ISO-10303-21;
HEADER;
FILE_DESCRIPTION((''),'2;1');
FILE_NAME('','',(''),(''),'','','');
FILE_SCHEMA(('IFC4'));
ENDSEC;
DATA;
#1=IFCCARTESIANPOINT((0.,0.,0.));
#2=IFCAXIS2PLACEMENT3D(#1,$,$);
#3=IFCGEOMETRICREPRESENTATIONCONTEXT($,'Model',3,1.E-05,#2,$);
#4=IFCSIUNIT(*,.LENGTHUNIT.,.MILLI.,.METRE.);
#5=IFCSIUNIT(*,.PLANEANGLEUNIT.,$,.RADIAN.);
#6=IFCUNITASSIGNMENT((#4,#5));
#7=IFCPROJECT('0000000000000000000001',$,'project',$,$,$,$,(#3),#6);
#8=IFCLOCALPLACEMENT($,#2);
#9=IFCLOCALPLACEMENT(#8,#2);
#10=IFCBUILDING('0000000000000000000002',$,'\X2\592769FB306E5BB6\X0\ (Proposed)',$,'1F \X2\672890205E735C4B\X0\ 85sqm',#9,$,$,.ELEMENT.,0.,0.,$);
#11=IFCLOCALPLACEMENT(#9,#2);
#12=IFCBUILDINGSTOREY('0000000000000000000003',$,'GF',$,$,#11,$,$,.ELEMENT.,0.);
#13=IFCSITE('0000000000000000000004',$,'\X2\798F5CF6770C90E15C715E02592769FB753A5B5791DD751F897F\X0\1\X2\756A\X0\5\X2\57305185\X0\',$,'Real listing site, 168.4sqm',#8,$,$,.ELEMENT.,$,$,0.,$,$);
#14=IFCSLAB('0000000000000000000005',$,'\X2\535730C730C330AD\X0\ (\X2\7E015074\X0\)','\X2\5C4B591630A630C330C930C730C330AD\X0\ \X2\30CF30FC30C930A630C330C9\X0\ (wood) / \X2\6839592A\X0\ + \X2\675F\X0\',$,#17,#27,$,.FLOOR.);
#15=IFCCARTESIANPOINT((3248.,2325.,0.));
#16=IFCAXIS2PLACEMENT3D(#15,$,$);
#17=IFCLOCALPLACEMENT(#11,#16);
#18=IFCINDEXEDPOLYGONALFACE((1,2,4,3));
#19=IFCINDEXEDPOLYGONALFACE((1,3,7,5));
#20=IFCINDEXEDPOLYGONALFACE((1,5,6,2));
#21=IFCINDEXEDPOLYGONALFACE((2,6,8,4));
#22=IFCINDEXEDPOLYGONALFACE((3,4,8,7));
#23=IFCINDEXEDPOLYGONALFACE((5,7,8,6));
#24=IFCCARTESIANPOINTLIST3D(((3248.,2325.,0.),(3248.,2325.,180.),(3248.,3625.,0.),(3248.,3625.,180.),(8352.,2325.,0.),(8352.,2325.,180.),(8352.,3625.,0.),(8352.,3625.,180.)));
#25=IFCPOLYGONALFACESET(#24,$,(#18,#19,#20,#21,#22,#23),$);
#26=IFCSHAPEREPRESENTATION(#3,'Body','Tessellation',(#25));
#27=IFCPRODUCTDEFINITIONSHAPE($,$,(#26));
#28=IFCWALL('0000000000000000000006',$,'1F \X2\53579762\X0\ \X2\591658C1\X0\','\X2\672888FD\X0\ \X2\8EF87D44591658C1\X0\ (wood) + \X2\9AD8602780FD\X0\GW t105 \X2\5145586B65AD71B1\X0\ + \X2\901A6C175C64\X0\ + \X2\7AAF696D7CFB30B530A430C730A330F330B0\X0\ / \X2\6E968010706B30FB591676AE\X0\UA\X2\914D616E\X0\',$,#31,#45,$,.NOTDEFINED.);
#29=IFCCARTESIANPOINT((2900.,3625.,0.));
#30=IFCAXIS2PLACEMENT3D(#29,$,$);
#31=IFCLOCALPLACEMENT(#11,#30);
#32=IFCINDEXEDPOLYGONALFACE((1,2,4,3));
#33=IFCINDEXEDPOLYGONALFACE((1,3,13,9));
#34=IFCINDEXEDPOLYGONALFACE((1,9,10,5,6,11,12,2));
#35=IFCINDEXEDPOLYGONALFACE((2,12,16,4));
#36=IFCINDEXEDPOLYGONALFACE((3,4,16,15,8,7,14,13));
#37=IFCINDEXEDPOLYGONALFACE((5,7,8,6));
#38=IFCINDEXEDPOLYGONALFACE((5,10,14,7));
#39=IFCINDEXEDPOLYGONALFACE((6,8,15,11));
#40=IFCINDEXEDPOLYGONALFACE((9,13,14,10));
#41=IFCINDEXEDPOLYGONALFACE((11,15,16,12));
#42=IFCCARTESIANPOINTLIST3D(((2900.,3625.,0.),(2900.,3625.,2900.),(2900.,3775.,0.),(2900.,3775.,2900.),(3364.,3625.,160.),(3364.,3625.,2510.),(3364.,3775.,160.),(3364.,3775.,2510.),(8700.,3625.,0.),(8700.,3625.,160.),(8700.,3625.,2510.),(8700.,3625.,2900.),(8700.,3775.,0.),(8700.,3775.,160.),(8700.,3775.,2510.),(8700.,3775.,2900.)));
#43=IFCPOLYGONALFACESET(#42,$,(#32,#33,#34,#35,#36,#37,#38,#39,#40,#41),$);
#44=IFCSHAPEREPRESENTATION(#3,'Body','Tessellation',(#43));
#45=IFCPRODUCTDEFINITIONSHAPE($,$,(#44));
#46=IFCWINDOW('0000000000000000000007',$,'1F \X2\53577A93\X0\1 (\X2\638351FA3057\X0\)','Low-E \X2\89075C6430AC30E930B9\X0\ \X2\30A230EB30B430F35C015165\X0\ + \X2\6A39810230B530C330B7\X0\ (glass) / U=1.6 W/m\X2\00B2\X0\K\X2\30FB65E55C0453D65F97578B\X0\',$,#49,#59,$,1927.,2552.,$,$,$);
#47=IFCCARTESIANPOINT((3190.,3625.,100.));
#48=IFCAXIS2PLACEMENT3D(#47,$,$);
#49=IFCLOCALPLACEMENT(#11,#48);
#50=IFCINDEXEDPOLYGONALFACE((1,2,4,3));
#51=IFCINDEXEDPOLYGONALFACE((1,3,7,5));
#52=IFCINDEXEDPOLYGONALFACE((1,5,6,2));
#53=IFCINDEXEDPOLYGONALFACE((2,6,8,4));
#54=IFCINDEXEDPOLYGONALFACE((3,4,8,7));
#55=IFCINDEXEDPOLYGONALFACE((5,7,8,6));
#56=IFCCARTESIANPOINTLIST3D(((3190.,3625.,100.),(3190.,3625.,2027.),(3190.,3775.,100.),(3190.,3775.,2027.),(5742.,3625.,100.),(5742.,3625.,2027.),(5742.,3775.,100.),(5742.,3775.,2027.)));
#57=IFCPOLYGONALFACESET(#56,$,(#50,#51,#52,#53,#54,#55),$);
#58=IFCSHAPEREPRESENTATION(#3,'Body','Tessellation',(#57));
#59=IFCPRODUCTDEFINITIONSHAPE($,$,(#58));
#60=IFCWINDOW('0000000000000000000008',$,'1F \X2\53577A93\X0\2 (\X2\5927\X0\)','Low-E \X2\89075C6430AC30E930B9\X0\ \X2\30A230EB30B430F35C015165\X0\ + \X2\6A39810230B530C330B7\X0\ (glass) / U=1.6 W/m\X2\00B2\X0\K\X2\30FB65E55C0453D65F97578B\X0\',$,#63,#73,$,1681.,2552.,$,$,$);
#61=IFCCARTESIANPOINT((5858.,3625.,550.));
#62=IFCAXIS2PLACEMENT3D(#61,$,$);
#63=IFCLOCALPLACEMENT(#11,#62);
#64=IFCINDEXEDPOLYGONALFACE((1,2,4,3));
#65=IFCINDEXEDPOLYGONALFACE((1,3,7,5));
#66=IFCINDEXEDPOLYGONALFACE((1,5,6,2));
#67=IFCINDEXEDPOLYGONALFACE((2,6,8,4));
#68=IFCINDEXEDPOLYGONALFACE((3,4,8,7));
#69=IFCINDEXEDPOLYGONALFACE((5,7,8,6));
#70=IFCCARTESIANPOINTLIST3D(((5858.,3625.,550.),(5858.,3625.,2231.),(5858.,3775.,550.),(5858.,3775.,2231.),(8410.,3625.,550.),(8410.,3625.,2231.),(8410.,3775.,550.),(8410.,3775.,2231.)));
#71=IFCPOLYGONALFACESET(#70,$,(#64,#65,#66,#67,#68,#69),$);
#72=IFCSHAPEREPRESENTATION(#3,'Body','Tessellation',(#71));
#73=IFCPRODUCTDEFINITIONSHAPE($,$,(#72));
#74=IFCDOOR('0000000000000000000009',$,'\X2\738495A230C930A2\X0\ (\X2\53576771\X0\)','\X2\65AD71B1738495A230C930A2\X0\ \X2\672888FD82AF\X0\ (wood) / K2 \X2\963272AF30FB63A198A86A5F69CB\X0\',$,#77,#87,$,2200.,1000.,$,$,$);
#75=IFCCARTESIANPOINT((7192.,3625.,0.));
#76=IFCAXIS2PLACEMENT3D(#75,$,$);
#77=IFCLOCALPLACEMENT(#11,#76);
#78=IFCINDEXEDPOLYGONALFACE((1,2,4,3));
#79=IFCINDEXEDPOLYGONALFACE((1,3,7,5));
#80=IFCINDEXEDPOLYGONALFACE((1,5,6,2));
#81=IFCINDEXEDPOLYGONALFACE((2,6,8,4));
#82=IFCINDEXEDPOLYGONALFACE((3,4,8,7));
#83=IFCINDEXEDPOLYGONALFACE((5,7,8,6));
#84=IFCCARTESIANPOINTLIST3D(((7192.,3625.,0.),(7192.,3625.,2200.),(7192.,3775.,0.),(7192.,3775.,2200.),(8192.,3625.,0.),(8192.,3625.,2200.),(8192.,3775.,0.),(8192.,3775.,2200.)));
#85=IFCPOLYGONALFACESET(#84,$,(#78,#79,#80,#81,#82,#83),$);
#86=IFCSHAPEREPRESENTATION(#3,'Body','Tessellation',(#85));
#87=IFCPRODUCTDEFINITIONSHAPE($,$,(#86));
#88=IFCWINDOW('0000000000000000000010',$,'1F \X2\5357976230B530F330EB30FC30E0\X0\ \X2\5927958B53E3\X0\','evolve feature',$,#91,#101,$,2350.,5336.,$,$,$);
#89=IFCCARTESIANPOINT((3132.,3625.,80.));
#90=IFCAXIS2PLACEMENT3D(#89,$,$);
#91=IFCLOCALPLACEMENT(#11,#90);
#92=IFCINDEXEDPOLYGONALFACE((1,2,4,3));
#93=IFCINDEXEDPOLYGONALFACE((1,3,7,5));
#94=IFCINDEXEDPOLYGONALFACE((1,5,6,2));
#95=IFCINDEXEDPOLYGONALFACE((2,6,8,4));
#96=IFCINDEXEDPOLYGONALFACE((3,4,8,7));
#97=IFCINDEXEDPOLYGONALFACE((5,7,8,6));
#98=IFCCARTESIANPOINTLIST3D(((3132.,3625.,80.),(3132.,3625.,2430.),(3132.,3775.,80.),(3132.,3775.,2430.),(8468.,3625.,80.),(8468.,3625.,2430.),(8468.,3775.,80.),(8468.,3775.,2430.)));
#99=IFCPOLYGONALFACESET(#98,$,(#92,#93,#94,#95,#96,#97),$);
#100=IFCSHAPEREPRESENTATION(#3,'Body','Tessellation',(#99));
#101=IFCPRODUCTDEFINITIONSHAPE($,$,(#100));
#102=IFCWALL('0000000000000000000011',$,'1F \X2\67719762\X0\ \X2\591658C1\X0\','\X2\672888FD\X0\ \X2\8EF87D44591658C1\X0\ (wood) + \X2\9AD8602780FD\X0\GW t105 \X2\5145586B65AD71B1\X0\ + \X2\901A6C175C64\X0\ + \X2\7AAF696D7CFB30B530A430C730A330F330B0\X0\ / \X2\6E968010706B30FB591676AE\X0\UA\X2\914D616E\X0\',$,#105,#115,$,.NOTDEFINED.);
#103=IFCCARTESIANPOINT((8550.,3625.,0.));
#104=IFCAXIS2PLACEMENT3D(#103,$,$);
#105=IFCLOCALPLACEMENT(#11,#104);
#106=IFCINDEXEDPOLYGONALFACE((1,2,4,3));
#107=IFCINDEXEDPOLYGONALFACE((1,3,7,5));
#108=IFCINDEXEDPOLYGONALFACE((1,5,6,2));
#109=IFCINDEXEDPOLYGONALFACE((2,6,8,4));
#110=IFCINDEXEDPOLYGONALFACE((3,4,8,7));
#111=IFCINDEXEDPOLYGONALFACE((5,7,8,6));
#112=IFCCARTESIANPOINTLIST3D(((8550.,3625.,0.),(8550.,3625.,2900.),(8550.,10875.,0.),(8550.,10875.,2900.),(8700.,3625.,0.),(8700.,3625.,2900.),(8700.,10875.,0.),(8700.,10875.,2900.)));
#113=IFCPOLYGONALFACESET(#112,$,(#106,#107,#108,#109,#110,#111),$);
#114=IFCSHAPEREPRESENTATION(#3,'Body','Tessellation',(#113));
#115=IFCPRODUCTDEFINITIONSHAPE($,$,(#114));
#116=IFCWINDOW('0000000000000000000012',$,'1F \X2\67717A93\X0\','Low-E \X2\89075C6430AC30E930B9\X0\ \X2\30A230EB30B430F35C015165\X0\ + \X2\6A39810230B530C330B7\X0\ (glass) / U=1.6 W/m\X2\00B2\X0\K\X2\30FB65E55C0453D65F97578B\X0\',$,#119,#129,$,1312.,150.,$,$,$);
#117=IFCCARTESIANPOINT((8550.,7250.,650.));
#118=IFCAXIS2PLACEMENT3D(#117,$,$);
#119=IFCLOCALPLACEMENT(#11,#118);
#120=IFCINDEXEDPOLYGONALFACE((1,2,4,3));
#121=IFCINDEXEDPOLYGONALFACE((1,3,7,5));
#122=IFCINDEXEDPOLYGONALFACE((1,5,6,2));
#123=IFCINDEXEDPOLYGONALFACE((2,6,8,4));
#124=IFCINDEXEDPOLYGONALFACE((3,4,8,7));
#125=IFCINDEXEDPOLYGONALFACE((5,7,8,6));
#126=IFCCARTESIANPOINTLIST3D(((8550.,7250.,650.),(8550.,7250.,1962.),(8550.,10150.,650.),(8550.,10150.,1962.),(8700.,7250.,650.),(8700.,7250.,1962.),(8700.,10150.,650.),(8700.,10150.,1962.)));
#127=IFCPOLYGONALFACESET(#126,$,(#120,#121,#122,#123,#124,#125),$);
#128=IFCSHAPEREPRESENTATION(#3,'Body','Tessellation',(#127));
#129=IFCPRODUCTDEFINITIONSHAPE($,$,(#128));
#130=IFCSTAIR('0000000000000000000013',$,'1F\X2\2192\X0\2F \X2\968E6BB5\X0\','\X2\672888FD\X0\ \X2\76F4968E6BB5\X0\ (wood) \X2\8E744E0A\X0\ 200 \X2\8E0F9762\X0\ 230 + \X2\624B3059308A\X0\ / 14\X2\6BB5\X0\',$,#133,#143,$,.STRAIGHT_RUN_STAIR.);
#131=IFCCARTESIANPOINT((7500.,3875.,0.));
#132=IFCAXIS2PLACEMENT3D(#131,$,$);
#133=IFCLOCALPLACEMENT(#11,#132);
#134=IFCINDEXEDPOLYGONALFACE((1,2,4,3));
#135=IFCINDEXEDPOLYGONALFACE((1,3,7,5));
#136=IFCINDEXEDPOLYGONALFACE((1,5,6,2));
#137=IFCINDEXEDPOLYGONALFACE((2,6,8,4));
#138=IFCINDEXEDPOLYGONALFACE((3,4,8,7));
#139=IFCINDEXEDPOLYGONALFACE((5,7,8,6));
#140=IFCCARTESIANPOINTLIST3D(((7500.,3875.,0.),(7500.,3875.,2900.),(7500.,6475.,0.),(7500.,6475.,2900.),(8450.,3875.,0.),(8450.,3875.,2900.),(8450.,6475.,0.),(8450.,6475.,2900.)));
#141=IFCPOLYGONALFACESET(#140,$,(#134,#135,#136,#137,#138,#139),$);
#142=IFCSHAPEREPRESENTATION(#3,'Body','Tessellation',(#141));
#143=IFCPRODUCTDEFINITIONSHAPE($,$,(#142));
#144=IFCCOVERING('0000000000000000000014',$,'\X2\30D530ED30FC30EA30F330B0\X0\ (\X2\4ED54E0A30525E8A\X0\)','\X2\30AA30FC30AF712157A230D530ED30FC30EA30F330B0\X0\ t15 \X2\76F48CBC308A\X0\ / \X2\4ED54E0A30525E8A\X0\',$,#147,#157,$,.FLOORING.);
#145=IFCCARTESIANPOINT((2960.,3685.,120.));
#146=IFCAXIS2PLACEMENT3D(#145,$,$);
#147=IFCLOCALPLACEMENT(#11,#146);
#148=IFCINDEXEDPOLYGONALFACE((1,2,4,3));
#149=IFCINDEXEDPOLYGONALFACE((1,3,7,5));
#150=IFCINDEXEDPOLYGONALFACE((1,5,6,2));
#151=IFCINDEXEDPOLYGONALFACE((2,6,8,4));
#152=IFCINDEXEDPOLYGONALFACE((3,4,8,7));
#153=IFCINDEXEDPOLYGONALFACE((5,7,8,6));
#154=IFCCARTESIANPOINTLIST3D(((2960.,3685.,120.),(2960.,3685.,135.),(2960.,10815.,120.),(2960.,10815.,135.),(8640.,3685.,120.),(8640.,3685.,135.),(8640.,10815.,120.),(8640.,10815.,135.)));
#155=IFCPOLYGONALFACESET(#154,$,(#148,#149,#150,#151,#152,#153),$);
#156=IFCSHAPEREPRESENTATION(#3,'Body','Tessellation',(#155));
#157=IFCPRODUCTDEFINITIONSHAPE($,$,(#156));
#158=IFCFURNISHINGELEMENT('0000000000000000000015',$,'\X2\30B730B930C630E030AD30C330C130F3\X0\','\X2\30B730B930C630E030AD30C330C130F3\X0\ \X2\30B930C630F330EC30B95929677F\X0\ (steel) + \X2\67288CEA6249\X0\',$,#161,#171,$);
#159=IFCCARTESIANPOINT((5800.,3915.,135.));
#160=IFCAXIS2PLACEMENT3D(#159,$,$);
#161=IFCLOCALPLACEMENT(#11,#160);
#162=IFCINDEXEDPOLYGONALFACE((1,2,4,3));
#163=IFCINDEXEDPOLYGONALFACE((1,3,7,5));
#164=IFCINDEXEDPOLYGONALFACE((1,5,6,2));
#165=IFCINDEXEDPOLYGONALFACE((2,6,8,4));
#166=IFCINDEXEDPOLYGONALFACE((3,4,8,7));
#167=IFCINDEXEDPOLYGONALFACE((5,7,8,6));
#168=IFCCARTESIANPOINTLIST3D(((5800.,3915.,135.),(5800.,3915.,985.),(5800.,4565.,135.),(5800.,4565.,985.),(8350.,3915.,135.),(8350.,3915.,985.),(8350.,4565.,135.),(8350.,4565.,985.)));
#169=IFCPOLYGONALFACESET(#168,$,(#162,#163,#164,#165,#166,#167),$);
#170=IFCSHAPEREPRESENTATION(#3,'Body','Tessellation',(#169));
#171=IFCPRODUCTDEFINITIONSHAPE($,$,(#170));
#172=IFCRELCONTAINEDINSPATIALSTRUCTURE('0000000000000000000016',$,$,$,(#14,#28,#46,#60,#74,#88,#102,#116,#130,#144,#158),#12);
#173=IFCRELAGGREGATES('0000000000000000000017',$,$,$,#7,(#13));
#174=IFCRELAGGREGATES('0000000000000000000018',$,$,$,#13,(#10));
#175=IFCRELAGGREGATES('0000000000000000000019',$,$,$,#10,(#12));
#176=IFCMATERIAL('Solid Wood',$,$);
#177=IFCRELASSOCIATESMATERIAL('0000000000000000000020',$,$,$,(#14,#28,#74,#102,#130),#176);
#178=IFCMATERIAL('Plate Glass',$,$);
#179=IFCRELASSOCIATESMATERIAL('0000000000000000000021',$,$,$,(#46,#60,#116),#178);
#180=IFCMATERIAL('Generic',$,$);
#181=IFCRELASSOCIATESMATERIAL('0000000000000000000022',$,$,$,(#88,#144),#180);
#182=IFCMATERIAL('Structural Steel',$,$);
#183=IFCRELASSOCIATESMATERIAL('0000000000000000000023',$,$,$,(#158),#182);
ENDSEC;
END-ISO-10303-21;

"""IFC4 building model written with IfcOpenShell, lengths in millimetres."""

from ifc_helpers import new_model, si_unit, frame, frame_2d, origin, place, context, project, spatial, rectangle, extrude, material, element, fill, save


model = new_model("IFC4")

# Units and contexts
model_context = context("Model", 3, precision=1e-05, world=origin())
ifc_project = project(units=[si_unit("LENGTHUNIT", "METRE", prefix="MILLI"), si_unit("PLANEANGLEUNIT", "RADIAN")], contexts=[model_context])

# Site, building, storey
site_placement = place(None, origin())
site = spatial("IfcSite", under=ifc_project, at=site_placement, Name="福島県郡山市大槻町字針生西1番5地内", ObjectType="Real listing site, 168.4sqm", CompositionType="ELEMENT", RefElevation=0.0)
building_placement = place(site_placement, origin())
building = spatial("IfcBuilding", under=site, at=building_placement, Name="大槻の家 (Proposed)", ObjectType="1F 木造平屋 85sqm", CompositionType="ELEMENT", ElevationOfRefHeight=0.0, ElevationOfTerrain=0.0)
storey_placement = place(building_placement, origin())
storey = spatial("IfcBuildingStorey", under=building, at=storey_placement, Name="GF", CompositionType="ELEMENT", Elevation=0.0)

# Slab
ifc_material_1 = material(Name="Solid Wood")
slab_1_placement = place(storey_placement, frame((3248.0, 2325.0, 0.0)))
element("IfcSlab", 1, at=slab_1_placement, inside=storey, material=ifc_material_1, Name="南デッキ (縁側)", Description="屋外ウッドデッキ ハードウッド (wood) / 根太 + 束", PredefinedType="FLOOR", context=model_context, shape_type="SweptSolid", body=[
    extrude(rectangle(XDim=5104.0, YDim=1300.0, at=frame_2d((2552.0, 650.0))), frame((3248.0, 2325.0, 0.0)), (0.0, 0.0, 1.0), 180.0),
])
ifc_material_2 = material(Name="Generic")

# Wall, openings, windows, door
wall_1_placement = place(storey_placement, frame((2900.0, 3625.0, 0.0)))
wall_1 = element("IfcWall", 2, at=wall_1_placement, inside=storey, material=ifc_material_1, Name="1F 南面 外壁", Description="木製 軸組外壁 (wood) + 高性能GW t105 充填断熱 + 通気層 + 窯業系サイディング / 準耐火・外皮UA配慮", PredefinedType="NOTDEFINED", context=model_context, shape_type="SweptSolid", body=[
    extrude(rectangle(XDim=5800.0, YDim=150.0, at=frame_2d((2900.0, 75.0))), frame((2900.0, 3625.0, 0.0)), (0.0, 0.0, 1.0), 2900.0),
])
opening_1_placement = place(storey_placement, frame((3190.0, 3625.0, 100.0)))
opening_1 = element("IfcOpeningElement", 3, at=opening_1_placement, cuts=wall_1, PredefinedType="NOTDEFINED", context=model_context, shape_type="SweptSolid", body=[
    extrude(rectangle(XDim=2552.0, YDim=150.0, at=frame_2d((1276.0, 75.0))), frame((3190.0, 3625.0, 100.0)), (0.0, 0.0, 1.0), 1927.0),
])
opening_2_placement = place(storey_placement, frame((5858.0, 3625.0, 550.0)))
opening_2 = element("IfcOpeningElement", 4, at=opening_2_placement, cuts=wall_1, PredefinedType="NOTDEFINED", context=model_context, shape_type="SweptSolid", body=[
    extrude(rectangle(XDim=2552.0, YDim=150.0, at=frame_2d((1276.0, 75.0))), frame((5858.0, 3625.0, 550.0)), (0.0, 0.0, 1.0), 1681.0),
])
opening_3_placement = place(storey_placement, frame((7192.0, 3625.0, 0.0)))
opening_3 = element("IfcOpeningElement", 5, at=opening_3_placement, cuts=wall_1, PredefinedType="NOTDEFINED", context=model_context, shape_type="SweptSolid", body=[
    extrude(rectangle(XDim=1000.0, YDim=150.0, at=frame_2d((500.0, 75.0))), frame((7192.0, 3625.0, 0.0)), (0.0, 0.0, 1.0), 2200.0),
])
opening_4_placement = place(storey_placement, frame((3132.0, 3625.0, 80.0)))
opening_4 = element("IfcOpeningElement", 6, at=opening_4_placement, cuts=wall_1, PredefinedType="NOTDEFINED", context=model_context, shape_type="SweptSolid", body=[
    extrude(rectangle(XDim=5336.0, YDim=150.0, at=frame_2d((2668.0, 75.0))), frame((3132.0, 3625.0, 80.0)), (0.0, 0.0, 1.0), 2350.0),
])
ifc_material_3 = material(Name="Plate Glass")
window_1_placement = place(storey_placement, frame((3190.0, 3625.0, 100.0)))
window_1 = element("IfcWindow", 7, at=window_1_placement, inside=storey, material=ifc_material_3, Name="1F 南窓1 (掃出し)", Description="Low-E 複層ガラス アルゴン封入 + 樹脂サッシ (glass) / U=1.6 W/m²K・日射取得型", OverallHeight=1927.0, OverallWidth=2552.0, context=model_context, shape_type="SweptSolid", body=[
    extrude(rectangle(XDim=2552.0, YDim=150.0, at=frame_2d((1276.0, 75.0))), frame((3190.0, 3625.0, 100.0)), (0.0, 0.0, 1.0), 1927.0),
])
fill(opening_1, window_1)
window_2_placement = place(storey_placement, frame((5858.0, 3625.0, 550.0)))
window_2 = element("IfcWindow", 8, at=window_2_placement, inside=storey, material=ifc_material_3, Name="1F 南窓2 (大)", Description="Low-E 複層ガラス アルゴン封入 + 樹脂サッシ (glass) / U=1.6 W/m²K・日射取得型", OverallHeight=1681.0, OverallWidth=2552.0, context=model_context, shape_type="SweptSolid", body=[
    extrude(rectangle(XDim=2552.0, YDim=150.0, at=frame_2d((1276.0, 75.0))), frame((5858.0, 3625.0, 550.0)), (0.0, 0.0, 1.0), 1681.0),
])
fill(opening_2, window_2)
door_placement = place(storey_placement, frame((7192.0, 3625.0, 0.0)))
door = element("IfcDoor", 9, at=door_placement, inside=storey, material=ifc_material_1, Name="玄関ドア (南東)", Description="断熱玄関ドア 木製芯 (wood) / K2 防犯・採風機構", OverallHeight=2200.0, OverallWidth=1000.0, context=model_context, shape_type="SweptSolid", body=[
    extrude(rectangle(XDim=1000.0, YDim=150.0, at=frame_2d((500.0, 75.0))), frame((7192.0, 3625.0, 0.0)), (0.0, 0.0, 1.0), 2200.0),
])
fill(opening_3, door)
window_3_placement = place(storey_placement, frame((3132.0, 3625.0, 80.0)))
window_3 = element("IfcWindow", 10, at=window_3_placement, inside=storey, material=ifc_material_2, Name="1F 南面サンルーム 大開口", Description="evolve feature", OverallHeight=2350.0, OverallWidth=5336.0, context=model_context, shape_type="SweptSolid", body=[
    extrude(rectangle(XDim=5336.0, YDim=150.0, at=frame_2d((2668.0, 75.0))), frame((3132.0, 3625.0, 80.0)), (0.0, 0.0, 1.0), 2350.0),
])
fill(opening_4, window_3)

# Wall, opening, window
wall_2_placement = place(storey_placement, frame((8550.0, 3625.0, 0.0)))
wall_2 = element("IfcWall", 11, at=wall_2_placement, inside=storey, material=ifc_material_1, Name="1F 東面 外壁", Description="木製 軸組外壁 (wood) + 高性能GW t105 充填断熱 + 通気層 + 窯業系サイディング / 準耐火・外皮UA配慮", PredefinedType="NOTDEFINED", context=model_context, shape_type="SweptSolid", body=[
    extrude(rectangle(XDim=150.0, YDim=7250.0, at=frame_2d((75.0, 3625.0))), frame((8550.0, 3625.0, 0.0)), (0.0, 0.0, 1.0), 2900.0),
])
opening_5_placement = place(storey_placement, frame((8550.0, 7250.0, 650.0)))
opening_5 = element("IfcOpeningElement", 12, at=opening_5_placement, cuts=wall_2, PredefinedType="NOTDEFINED", context=model_context, shape_type="SweptSolid", body=[
    extrude(rectangle(XDim=150.0, YDim=2900.0, at=frame_2d((75.0, 1450.0))), frame((8550.0, 7250.0, 650.0)), (0.0, 0.0, 1.0), 1312.0),
])
window_4_placement = place(storey_placement, frame((8550.0, 7250.0, 650.0)))
window_4 = element("IfcWindow", 13, at=window_4_placement, inside=storey, material=ifc_material_3, Name="1F 東窓", Description="Low-E 複層ガラス アルゴン封入 + 樹脂サッシ (glass) / U=1.6 W/m²K・日射取得型", OverallHeight=1312.0, OverallWidth=150.0, context=model_context, shape_type="SweptSolid", body=[
    extrude(rectangle(XDim=150.0, YDim=2900.0, at=frame_2d((75.0, 1450.0))), frame((8550.0, 7250.0, 650.0)), (0.0, 0.0, 1.0), 1312.0),
])
fill(opening_5, window_4)

# Stair
stair_placement = place(storey_placement, frame((7500.0, 3875.0, 0.0)))
element("IfcStair", 14, at=stair_placement, inside=storey, material=ifc_material_1, Name="1F→2F 階段", Description="木製 直階段 (wood) 蹴上 200 踏面 230 + 手すり / 14段", PredefinedType="STRAIGHT_RUN_STAIR", context=model_context, shape_type="SweptSolid", body=[
    extrude(rectangle(XDim=950.0, YDim=2600.0, at=frame_2d((475.0, 1300.0))), frame((7500.0, 3875.0, 0.0)), (0.0, 0.0, 1.0), 2900.0),
])

# Covering
covering_placement = place(storey_placement, frame((2960.0, 3685.0, 120.0)))
element("IfcCovering", 15, at=covering_placement, inside=storey, material=ifc_material_2, Name="フローリング (仕上げ床)", Description="オーク無垢フローリング t15 直貼り / 仕上げ床", PredefinedType="FLOORING", context=model_context, shape_type="SweptSolid", body=[
    extrude(rectangle(XDim=5680.0, YDim=7130.0, at=frame_2d((2840.0, 3565.0))), frame((2960.0, 3685.0, 120.0)), (0.0, 0.0, 1.0), 15.0),
])

# Furnishing element
ifc_material_4 = material(Name="Structural Steel")
furnishing_placement = place(storey_placement, frame((5800.0, 3915.0, 135.0)))
element("IfcFurnishingElement", 16, at=furnishing_placement, inside=storey, material=ifc_material_4, Name="システムキッチン", Description="システムキッチン ステンレス天板 (steel) + 木質扉", context=model_context, shape_type="SweptSolid", body=[
    extrude(rectangle(XDim=2550.0, YDim=650.0, at=frame_2d((1275.0, 325.0))), frame((5800.0, 3915.0, 135.0)), (0.0, 0.0, 1.0), 850.0),
])

save(model, "model.ifc")
